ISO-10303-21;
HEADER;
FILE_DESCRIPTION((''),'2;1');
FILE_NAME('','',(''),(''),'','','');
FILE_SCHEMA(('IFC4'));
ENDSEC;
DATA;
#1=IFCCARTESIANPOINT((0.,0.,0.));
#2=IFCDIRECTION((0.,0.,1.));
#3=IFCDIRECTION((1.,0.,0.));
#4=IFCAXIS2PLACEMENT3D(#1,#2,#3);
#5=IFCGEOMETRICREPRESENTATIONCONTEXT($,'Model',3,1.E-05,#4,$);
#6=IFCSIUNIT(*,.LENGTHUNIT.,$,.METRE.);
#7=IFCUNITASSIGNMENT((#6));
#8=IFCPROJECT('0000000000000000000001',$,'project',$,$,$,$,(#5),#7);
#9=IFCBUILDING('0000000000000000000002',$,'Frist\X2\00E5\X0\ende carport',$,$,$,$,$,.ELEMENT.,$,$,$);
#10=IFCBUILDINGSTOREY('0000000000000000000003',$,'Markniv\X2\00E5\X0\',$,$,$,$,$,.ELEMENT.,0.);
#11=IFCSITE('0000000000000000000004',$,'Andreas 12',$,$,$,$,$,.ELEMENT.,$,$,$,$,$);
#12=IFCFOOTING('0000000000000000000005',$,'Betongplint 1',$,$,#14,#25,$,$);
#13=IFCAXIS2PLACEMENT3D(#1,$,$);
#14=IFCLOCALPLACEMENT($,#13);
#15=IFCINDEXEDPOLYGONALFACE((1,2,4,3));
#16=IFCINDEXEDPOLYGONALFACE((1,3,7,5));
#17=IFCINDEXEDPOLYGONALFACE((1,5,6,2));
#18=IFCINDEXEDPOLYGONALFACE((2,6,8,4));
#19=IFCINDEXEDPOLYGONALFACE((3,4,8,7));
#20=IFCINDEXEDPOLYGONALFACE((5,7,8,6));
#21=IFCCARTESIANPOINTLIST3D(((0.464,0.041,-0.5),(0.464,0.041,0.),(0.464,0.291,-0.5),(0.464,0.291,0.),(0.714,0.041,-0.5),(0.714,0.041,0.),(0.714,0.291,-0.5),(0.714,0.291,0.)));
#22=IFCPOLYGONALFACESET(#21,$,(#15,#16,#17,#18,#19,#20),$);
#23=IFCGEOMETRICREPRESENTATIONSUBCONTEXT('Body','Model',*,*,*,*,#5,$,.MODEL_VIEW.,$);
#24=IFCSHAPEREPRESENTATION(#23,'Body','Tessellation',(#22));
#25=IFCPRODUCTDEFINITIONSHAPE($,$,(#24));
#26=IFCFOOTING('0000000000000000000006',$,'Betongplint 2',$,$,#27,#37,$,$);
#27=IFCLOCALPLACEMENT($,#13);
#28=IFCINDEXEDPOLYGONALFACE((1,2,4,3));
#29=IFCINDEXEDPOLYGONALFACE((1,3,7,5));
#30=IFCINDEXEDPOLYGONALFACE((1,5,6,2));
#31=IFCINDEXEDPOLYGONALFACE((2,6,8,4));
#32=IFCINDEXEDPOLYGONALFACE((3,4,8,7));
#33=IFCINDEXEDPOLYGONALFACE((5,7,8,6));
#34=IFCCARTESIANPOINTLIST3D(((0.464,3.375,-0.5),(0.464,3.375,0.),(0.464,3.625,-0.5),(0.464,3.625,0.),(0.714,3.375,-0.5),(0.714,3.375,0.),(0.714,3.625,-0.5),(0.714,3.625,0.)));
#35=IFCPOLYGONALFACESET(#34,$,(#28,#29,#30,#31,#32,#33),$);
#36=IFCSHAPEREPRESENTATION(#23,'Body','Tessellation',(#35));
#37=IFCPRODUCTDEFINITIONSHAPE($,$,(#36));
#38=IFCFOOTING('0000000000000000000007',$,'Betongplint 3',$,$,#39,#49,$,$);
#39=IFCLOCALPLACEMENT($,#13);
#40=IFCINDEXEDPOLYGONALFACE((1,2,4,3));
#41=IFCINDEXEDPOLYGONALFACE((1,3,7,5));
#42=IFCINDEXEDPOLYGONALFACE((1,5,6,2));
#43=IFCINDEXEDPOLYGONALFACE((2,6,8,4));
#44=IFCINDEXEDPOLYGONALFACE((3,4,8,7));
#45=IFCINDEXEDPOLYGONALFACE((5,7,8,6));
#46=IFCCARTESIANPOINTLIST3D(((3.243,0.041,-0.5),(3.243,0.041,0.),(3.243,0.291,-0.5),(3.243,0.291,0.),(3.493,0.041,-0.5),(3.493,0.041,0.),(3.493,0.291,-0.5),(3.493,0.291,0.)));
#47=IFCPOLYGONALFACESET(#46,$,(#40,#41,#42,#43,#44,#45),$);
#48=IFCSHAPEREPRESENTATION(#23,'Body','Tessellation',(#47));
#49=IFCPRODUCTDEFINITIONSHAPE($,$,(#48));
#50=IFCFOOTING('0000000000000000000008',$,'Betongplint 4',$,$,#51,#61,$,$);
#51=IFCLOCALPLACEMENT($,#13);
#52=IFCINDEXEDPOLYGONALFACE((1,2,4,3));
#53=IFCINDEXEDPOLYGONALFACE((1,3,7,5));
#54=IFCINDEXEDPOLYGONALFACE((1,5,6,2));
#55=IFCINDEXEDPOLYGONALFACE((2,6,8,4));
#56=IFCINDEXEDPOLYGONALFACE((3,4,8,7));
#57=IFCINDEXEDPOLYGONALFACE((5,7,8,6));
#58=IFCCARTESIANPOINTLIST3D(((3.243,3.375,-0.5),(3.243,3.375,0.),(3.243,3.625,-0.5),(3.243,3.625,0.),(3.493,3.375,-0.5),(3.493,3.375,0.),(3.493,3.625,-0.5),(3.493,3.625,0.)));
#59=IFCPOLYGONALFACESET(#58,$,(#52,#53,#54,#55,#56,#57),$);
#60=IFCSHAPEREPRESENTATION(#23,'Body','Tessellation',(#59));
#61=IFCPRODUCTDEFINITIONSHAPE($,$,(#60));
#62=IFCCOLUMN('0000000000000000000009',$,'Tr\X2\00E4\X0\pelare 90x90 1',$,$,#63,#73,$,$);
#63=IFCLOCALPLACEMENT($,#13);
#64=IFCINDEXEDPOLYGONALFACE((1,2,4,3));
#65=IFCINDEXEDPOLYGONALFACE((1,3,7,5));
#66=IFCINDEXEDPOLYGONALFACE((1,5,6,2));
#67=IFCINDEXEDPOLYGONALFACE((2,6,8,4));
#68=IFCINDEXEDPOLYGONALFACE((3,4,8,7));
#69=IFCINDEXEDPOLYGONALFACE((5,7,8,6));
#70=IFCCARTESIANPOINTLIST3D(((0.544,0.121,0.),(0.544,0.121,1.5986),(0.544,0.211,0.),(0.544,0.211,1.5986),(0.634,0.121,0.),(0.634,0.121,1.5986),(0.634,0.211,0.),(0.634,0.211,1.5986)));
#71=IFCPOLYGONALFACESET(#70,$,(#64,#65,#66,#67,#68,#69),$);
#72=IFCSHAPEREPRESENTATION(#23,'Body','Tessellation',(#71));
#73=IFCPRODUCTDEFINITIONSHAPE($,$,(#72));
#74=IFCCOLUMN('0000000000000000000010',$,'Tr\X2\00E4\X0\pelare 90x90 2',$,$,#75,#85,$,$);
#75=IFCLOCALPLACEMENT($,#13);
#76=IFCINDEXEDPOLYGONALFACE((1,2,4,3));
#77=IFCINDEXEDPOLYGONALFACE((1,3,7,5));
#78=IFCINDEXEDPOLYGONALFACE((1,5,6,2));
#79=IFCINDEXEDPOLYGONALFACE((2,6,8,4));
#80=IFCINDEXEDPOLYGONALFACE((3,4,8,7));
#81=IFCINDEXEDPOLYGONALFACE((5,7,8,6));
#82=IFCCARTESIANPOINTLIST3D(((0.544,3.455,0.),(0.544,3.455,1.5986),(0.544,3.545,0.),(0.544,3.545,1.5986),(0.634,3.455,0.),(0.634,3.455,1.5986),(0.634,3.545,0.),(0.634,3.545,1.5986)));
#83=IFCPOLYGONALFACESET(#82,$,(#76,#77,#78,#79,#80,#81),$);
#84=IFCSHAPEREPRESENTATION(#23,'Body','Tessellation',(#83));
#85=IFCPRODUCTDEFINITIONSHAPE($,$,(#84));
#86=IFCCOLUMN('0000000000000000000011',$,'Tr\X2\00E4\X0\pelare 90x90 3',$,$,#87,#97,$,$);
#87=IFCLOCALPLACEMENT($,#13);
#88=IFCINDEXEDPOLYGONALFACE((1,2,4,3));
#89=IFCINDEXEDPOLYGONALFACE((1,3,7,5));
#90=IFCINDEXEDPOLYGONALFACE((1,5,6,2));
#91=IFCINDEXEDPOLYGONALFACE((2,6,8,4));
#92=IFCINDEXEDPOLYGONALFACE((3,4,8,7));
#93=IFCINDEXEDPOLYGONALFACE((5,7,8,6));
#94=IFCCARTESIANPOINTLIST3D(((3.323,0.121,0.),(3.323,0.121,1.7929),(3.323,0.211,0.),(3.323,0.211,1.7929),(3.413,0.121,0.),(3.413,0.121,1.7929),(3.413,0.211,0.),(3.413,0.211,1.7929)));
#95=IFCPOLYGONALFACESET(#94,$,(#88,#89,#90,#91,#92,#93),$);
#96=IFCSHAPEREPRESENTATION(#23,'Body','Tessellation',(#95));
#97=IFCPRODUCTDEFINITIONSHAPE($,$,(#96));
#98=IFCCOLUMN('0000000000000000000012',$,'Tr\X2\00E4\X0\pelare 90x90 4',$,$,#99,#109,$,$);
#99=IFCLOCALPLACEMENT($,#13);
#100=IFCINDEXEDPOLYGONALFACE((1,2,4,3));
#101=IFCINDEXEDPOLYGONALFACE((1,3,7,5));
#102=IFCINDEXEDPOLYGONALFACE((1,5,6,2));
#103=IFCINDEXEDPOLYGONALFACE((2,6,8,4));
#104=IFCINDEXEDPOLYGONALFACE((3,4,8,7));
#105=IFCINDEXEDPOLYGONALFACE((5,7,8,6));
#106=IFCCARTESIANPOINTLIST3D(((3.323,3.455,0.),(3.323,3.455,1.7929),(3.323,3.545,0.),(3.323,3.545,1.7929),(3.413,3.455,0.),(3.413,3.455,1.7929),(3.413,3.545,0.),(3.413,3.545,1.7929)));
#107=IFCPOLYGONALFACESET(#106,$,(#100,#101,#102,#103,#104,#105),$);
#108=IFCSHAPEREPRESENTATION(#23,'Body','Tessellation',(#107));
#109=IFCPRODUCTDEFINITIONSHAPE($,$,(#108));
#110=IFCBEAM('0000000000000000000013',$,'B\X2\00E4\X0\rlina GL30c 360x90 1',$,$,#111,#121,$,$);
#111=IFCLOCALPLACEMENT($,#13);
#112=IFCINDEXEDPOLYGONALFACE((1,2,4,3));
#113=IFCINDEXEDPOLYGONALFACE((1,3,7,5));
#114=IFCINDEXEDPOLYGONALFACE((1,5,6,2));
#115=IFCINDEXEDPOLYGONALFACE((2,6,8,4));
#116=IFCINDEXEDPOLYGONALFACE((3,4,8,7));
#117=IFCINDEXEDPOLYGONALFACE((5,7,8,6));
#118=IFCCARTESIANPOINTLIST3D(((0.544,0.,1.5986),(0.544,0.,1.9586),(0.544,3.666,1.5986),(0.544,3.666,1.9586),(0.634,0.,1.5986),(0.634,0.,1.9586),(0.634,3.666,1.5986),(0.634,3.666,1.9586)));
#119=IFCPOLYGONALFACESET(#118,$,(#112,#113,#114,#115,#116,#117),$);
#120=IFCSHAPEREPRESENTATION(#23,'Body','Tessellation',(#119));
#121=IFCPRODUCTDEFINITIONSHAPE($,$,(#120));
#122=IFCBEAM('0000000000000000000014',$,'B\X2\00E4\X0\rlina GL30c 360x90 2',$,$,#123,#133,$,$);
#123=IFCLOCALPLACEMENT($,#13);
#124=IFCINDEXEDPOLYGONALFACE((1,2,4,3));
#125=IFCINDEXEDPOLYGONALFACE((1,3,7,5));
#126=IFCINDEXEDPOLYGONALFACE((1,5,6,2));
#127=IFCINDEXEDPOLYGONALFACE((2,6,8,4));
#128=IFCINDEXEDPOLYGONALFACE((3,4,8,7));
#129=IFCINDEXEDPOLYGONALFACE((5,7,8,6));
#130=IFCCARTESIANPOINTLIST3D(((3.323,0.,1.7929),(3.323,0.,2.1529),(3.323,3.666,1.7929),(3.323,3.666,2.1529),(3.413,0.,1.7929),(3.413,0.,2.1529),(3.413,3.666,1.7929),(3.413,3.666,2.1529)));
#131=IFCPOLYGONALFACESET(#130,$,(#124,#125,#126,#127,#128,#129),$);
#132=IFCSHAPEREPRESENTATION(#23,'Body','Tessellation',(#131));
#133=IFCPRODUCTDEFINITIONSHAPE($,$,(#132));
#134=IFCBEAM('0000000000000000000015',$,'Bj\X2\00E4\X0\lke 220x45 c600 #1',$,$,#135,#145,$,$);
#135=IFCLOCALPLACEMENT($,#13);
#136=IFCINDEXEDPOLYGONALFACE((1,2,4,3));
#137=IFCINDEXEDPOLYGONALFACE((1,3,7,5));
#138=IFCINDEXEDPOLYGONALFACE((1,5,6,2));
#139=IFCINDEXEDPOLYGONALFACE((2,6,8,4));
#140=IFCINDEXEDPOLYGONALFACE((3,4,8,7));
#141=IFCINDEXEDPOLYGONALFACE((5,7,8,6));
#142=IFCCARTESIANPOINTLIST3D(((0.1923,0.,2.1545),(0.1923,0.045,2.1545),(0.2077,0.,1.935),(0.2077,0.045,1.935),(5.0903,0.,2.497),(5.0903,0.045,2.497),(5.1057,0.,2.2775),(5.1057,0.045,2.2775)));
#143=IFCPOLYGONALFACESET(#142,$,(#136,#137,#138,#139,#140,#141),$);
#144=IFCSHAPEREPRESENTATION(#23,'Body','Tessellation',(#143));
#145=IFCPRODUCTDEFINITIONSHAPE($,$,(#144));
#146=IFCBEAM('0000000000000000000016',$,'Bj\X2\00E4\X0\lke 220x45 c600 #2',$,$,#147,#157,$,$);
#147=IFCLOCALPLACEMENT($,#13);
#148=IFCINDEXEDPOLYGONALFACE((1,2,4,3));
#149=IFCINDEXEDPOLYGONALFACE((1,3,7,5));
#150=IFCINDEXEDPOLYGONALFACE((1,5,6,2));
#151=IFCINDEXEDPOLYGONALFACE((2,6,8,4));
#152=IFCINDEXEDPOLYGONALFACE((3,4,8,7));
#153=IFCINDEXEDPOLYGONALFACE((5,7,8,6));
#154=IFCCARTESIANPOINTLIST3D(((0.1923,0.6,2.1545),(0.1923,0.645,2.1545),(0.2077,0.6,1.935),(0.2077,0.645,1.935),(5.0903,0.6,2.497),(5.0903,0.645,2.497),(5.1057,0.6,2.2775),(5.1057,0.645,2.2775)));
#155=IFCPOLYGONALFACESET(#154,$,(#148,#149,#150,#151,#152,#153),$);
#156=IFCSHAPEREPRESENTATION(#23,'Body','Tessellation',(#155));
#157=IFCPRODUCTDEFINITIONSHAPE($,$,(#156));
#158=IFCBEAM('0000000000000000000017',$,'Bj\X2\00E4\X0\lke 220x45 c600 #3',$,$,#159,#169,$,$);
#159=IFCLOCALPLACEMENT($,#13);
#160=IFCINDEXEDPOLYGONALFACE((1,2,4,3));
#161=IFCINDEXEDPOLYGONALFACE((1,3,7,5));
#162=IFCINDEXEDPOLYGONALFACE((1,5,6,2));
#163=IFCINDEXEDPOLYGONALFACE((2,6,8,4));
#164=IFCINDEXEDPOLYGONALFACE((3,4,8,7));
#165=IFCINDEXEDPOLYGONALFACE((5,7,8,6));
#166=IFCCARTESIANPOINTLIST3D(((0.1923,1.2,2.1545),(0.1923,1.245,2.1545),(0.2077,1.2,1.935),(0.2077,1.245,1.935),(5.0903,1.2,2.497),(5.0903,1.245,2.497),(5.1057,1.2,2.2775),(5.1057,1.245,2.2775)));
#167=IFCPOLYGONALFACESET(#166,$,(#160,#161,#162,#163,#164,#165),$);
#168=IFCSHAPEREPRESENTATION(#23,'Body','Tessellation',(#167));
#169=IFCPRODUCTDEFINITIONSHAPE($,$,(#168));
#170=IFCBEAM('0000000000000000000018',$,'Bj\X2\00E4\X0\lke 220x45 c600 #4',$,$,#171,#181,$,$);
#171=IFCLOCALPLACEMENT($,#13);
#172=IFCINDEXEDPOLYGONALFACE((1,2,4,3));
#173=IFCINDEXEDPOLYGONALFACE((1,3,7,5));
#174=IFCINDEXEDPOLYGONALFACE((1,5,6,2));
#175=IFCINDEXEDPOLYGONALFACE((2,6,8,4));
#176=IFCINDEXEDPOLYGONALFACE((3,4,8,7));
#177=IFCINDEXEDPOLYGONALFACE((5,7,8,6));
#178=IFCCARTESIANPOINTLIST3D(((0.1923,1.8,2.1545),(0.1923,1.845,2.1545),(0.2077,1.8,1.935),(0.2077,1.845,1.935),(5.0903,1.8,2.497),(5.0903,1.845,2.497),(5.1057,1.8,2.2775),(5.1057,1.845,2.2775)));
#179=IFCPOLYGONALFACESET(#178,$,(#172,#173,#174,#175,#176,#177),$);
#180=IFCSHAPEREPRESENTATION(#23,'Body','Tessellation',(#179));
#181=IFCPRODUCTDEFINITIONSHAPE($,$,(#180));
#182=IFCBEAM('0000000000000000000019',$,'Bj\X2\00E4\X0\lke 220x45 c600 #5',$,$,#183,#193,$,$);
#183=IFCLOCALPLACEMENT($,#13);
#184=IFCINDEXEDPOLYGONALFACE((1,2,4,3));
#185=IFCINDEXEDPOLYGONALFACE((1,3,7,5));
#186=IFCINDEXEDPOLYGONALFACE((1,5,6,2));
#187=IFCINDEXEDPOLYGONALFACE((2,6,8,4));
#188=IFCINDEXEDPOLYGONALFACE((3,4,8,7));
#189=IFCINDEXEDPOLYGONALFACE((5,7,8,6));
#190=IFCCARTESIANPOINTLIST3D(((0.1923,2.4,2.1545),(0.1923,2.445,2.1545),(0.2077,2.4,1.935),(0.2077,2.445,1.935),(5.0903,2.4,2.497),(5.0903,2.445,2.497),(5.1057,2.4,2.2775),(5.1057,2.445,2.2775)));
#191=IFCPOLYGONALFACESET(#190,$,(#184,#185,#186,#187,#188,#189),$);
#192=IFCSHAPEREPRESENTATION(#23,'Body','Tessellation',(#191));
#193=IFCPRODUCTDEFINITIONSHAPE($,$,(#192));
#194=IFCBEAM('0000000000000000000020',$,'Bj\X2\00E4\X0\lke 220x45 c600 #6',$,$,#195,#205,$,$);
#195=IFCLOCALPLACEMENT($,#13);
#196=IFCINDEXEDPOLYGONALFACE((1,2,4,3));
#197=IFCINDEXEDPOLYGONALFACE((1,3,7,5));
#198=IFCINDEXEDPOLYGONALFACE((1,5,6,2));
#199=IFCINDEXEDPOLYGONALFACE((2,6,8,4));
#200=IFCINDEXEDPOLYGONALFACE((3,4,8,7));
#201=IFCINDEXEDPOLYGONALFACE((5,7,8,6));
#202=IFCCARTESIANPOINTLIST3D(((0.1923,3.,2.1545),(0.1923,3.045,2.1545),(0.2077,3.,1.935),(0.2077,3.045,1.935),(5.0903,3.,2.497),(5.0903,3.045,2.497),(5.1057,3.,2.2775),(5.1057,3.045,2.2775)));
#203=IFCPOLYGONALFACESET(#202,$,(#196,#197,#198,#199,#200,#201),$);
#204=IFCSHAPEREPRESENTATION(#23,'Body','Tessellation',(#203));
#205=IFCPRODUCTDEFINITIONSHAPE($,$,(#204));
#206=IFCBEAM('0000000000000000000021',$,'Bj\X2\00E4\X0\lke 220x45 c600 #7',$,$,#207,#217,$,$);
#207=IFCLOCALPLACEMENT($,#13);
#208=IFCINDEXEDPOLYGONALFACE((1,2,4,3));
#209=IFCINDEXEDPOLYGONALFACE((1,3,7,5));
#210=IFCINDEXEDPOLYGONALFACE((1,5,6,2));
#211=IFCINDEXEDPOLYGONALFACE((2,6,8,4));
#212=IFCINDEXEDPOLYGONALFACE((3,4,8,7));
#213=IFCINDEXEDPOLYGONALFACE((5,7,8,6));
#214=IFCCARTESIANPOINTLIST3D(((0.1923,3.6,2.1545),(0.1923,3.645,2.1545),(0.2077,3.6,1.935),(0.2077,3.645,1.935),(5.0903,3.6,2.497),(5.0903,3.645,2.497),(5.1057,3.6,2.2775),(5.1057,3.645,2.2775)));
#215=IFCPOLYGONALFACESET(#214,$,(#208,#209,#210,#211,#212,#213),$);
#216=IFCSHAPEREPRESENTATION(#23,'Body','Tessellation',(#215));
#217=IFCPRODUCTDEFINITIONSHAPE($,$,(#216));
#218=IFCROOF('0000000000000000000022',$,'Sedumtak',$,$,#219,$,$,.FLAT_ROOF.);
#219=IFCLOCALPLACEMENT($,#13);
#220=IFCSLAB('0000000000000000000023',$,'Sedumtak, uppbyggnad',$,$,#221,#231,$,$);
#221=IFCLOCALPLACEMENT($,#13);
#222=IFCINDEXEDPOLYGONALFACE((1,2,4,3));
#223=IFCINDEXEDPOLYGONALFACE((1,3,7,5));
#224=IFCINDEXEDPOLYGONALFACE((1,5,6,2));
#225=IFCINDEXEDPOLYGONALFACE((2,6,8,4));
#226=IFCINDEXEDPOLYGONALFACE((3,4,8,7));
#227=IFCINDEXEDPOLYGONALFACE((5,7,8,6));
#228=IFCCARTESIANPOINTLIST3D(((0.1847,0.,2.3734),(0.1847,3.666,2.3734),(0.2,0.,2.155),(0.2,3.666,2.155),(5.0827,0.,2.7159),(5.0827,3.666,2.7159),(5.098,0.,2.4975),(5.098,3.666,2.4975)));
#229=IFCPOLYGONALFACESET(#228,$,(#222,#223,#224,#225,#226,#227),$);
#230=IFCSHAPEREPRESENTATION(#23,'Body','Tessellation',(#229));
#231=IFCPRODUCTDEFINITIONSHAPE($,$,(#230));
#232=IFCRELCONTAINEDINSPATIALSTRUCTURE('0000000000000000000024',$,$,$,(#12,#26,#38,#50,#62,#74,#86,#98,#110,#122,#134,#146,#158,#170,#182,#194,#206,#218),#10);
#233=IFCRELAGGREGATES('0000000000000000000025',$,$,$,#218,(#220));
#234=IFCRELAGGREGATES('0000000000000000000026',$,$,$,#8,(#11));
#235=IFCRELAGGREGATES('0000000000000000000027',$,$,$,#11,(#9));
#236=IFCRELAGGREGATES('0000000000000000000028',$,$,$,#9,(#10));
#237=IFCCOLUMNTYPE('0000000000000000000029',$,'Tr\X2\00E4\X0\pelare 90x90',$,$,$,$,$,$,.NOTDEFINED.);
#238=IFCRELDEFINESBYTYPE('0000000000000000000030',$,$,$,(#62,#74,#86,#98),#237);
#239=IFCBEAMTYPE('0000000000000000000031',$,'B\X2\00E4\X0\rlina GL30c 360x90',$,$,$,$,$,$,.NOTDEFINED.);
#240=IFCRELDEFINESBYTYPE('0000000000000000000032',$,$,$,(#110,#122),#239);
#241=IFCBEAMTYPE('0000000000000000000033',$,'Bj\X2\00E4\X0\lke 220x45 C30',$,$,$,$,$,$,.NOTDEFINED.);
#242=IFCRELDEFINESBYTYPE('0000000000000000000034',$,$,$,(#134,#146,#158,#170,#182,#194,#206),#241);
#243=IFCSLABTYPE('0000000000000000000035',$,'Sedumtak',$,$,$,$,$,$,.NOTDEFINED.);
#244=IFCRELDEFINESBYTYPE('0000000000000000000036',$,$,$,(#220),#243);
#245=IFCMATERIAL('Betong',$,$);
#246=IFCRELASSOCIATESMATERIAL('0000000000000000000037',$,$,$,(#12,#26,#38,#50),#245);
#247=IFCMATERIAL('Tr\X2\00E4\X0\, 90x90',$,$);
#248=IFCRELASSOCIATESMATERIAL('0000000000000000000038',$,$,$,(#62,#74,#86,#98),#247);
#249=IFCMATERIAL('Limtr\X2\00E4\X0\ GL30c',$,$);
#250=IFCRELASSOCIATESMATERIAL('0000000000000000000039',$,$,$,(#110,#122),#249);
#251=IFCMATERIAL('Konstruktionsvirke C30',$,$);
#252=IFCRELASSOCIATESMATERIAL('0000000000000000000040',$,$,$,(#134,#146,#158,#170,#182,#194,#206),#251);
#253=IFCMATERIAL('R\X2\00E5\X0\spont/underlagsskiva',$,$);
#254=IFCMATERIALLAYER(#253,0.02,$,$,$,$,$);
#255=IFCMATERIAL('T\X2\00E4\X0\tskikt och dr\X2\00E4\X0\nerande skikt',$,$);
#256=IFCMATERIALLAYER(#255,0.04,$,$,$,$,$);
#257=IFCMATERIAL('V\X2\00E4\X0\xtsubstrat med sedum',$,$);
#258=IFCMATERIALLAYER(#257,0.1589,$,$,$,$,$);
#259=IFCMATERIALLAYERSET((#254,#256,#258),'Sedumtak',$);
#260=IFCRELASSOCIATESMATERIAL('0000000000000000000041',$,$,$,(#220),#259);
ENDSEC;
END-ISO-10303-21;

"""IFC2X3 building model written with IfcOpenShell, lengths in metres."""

from ifc_helpers import new_model, si_unit, frame, frame_2d, origin, origin_with_axes, origin_2d, place, context, subcontext, project, spatial, rectangle, extrude, material, layer, layer_set, layer_usage, type_object, element, aggregate, save


model = new_model("IFC2X3")

# Units and contexts
model_context = context("Model", 3, precision=1e-05, world=origin_with_axes())
body_context = subcontext(model_context, "Body", "Model", "MODEL_VIEW")
ifc_project = project(units=[si_unit("LENGTHUNIT", "METRE")], contexts=[model_context])

# Site, building, storey
site = spatial("IfcSite", under=ifc_project, Name="Andreas 12", CompositionType="ELEMENT")
building = spatial("IfcBuilding", under=site, Name="Fristående carport", CompositionType="ELEMENT")
storey = spatial("IfcBuildingStorey", under=building, Name="Marknivå", CompositionType="ELEMENT", Elevation=0.0)

# Footings
ifc_material_1 = material(Name="Betong")
for number, where, z_axis, x_axis, name in (
    (1, (0.589, 0.166, -0.5), (0.0, 0.0, 1.0), (1.0, 0.0, 0.0), "Betongplint 1"),
    (2, (0.589, 3.5, -0.5), (0.0, 0.0, 1.0), (1.0, 0.0, 0.0), "Betongplint 2"),
    (3, (3.368, 0.166, -0.5), (0.0, 0.0, 1.0), (1.0, 0.0, 0.0), "Betongplint 3"),
    (4, (3.368, 3.5, -0.5), (0.0, 0.0, 1.0), (1.0, 0.0, 0.0), "Betongplint 4"),
):
    element("IfcFooting", number, at=place(None, frame(where, z_axis=z_axis, x_axis=x_axis)), inside=storey, material=ifc_material_1, Name=name, context=body_context, shape_type="SweptSolid", body=[
        extrude(rectangle(XDim=0.25, YDim=0.25, at=origin_2d()), origin(), (0.0, 0.0, 1.0), 0.5),
    ])

# Columns
ifc_material_2 = material(Name="Trä, 90x90")
column_type = type_object("IfcColumnType", Name="Träpelare 90x90", PredefinedType="NOTDEFINED")
for number, where, z_axis, x_axis, name in (
    (5, (0.589, 0.166, 0.0), (0.0, 0.0, 1.0), (1.0, 0.0, 0.0), "Träpelare 90x90 1"),
    (6, (0.589, 3.5, 0.0), (0.0, 0.0, 1.0), (1.0, 0.0, 0.0), "Träpelare 90x90 2"),
):
    element("IfcColumn", number, at=place(None, frame(where, z_axis=z_axis, x_axis=x_axis)), inside=storey, type_object=column_type, material=ifc_material_2, Name=name, context=body_context, shape_type="SweptSolid", body=[
        extrude(rectangle(XDim=0.09, YDim=0.09, at=origin_2d()), origin(), (0.0, 0.0, 1.0), 1.5986),
    ])
for number, where, z_axis, x_axis, name in (
    (7, (3.368, 0.166, 0.0), (0.0, 0.0, 1.0), (1.0, 0.0, 0.0), "Träpelare 90x90 3"),
    (8, (3.368, 3.5, 0.0), (0.0, 0.0, 1.0), (1.0, 0.0, 0.0), "Träpelare 90x90 4"),
):
    element("IfcColumn", number, at=place(None, frame(where, z_axis=z_axis, x_axis=x_axis)), inside=storey, type_object=column_type, material=ifc_material_2, Name=name, context=body_context, shape_type="SweptSolid", body=[
        extrude(rectangle(XDim=0.09, YDim=0.09, at=origin_2d()), origin(), (0.0, 0.0, 1.0), 1.7929),
    ])

# Beams
ifc_material_3 = material(Name="Limträ GL30c")
beam_type_1 = type_object("IfcBeamType", Name="Bärlina GL30c 360x90", PredefinedType="NOTDEFINED")
for number, where, z_axis, x_axis, name in (
    (9, (0.589, 0.0, 1.7786), (0.0, 1.0, 0.0), (1.0, 0.0, 0.0), "Bärlina GL30c 360x90 1"),
    (10, (3.368, 0.0, 1.9729), (0.0, 1.0, 0.0), (1.0, 0.0, 0.0), "Bärlina GL30c 360x90 2"),
):
    element("IfcBeam", number, at=place(None, frame(where, z_axis=z_axis, x_axis=x_axis)), inside=storey, type_object=beam_type_1, material=ifc_material_3, Name=name, context=body_context, shape_type="SweptSolid", body=[
        extrude(rectangle(XDim=0.09, YDim=0.36, at=origin_2d()), origin(), (0.0, 0.0, 1.0), 3.666),
    ])
ifc_material_4 = material(Name="Konstruktionsvirke C30")
beam_type_2 = type_object("IfcBeamType", Name="Bjälke 220x45 C30", PredefinedType="NOTDEFINED")
for number, where, z_axis, x_axis, name in (
    (11, (0.2, 0.0225, 2.0448), (0.997564, 0.0, 0.069756), (0.0, 1.0, 0.0), "Bjälke 220x45 c600 #1"),
    (12, (0.2, 0.6225, 2.0448), (0.997564, 0.0, 0.069756), (0.0, 1.0, 0.0), "Bjälke 220x45 c600 #2"),
    (13, (0.2, 1.2225, 2.0448), (0.997564, 0.0, 0.069756), (0.0, 1.0, 0.0), "Bjälke 220x45 c600 #3"),
    (14, (0.2, 1.8225, 2.0448), (0.997564, 0.0, 0.069756), (0.0, 1.0, 0.0), "Bjälke 220x45 c600 #4"),
    (15, (0.2, 2.4225, 2.0448), (0.997564, 0.0, 0.069756), (0.0, 1.0, 0.0), "Bjälke 220x45 c600 #5"),
    (16, (0.2, 3.0225, 2.0448), (0.997564, 0.0, 0.069756), (0.0, 1.0, 0.0), "Bjälke 220x45 c600 #6"),
    (17, (0.2, 3.6225, 2.0448), (0.997564, 0.0, 0.069756), (0.0, 1.0, 0.0), "Bjälke 220x45 c600 #7"),
):
    element("IfcBeam", number, at=place(None, frame(where, z_axis=z_axis, x_axis=x_axis)), inside=storey, type_object=beam_type_2, material=ifc_material_4, Name=name, context=body_context, shape_type="SweptSolid", body=[
        extrude(rectangle(XDim=0.045, YDim=0.22, at=origin_2d()), origin(), (0.0, 0.0, 1.0), 4.91),
    ])

# Roof, slab
roof = element("IfcRoof", 18, inside=storey, Name="Sedumtak", ShapeType="FLAT_ROOF")
ifc_material_5 = material(Name="Råspont/underlagsskiva")
ifc_layer_1 = layer(ifc_material_5, 0.02)
ifc_material_6 = material(Name="Tätskikt och dränerande skikt")
ifc_layer_2 = layer(ifc_material_6, 0.04)
ifc_material_7 = material(Name="Växtsubstrat med sedum")
ifc_layer_3 = layer(ifc_material_7, 0.1589)
ifc_layer_set = layer_set([ifc_layer_1, ifc_layer_2, ifc_layer_3], Name="Sedumtak")
ifc_layer_usage = layer_usage(ifc_layer_set, "AXIS3", "POSITIVE", 0.0)
slab_type_1 = type_object("IfcSlabType", Name="Sedumtak", PredefinedType="NOTDEFINED")
slab_1_placement = place(None, frame((0.2, 0.0, 2.155), z_axis=(-0.069756, 0.0, 0.997564), x_axis=(0.997564, 0.0, 0.069756)))
slab_1 = element("IfcSlab", 19, at=slab_1_placement, type_object=slab_type_1, material=ifc_layer_usage, Name="Sedumtak, uppbyggnad", context=body_context, shape_type="SweptSolid", body=[
    extrude(rectangle(XDim=4.91, YDim=3.666, at=frame_2d((2.455, 1.833))), origin(), (0.0, 0.0, 1.0), 0.2189),
])
aggregate(roof, [slab_1])

save(model, "model.ifc")
